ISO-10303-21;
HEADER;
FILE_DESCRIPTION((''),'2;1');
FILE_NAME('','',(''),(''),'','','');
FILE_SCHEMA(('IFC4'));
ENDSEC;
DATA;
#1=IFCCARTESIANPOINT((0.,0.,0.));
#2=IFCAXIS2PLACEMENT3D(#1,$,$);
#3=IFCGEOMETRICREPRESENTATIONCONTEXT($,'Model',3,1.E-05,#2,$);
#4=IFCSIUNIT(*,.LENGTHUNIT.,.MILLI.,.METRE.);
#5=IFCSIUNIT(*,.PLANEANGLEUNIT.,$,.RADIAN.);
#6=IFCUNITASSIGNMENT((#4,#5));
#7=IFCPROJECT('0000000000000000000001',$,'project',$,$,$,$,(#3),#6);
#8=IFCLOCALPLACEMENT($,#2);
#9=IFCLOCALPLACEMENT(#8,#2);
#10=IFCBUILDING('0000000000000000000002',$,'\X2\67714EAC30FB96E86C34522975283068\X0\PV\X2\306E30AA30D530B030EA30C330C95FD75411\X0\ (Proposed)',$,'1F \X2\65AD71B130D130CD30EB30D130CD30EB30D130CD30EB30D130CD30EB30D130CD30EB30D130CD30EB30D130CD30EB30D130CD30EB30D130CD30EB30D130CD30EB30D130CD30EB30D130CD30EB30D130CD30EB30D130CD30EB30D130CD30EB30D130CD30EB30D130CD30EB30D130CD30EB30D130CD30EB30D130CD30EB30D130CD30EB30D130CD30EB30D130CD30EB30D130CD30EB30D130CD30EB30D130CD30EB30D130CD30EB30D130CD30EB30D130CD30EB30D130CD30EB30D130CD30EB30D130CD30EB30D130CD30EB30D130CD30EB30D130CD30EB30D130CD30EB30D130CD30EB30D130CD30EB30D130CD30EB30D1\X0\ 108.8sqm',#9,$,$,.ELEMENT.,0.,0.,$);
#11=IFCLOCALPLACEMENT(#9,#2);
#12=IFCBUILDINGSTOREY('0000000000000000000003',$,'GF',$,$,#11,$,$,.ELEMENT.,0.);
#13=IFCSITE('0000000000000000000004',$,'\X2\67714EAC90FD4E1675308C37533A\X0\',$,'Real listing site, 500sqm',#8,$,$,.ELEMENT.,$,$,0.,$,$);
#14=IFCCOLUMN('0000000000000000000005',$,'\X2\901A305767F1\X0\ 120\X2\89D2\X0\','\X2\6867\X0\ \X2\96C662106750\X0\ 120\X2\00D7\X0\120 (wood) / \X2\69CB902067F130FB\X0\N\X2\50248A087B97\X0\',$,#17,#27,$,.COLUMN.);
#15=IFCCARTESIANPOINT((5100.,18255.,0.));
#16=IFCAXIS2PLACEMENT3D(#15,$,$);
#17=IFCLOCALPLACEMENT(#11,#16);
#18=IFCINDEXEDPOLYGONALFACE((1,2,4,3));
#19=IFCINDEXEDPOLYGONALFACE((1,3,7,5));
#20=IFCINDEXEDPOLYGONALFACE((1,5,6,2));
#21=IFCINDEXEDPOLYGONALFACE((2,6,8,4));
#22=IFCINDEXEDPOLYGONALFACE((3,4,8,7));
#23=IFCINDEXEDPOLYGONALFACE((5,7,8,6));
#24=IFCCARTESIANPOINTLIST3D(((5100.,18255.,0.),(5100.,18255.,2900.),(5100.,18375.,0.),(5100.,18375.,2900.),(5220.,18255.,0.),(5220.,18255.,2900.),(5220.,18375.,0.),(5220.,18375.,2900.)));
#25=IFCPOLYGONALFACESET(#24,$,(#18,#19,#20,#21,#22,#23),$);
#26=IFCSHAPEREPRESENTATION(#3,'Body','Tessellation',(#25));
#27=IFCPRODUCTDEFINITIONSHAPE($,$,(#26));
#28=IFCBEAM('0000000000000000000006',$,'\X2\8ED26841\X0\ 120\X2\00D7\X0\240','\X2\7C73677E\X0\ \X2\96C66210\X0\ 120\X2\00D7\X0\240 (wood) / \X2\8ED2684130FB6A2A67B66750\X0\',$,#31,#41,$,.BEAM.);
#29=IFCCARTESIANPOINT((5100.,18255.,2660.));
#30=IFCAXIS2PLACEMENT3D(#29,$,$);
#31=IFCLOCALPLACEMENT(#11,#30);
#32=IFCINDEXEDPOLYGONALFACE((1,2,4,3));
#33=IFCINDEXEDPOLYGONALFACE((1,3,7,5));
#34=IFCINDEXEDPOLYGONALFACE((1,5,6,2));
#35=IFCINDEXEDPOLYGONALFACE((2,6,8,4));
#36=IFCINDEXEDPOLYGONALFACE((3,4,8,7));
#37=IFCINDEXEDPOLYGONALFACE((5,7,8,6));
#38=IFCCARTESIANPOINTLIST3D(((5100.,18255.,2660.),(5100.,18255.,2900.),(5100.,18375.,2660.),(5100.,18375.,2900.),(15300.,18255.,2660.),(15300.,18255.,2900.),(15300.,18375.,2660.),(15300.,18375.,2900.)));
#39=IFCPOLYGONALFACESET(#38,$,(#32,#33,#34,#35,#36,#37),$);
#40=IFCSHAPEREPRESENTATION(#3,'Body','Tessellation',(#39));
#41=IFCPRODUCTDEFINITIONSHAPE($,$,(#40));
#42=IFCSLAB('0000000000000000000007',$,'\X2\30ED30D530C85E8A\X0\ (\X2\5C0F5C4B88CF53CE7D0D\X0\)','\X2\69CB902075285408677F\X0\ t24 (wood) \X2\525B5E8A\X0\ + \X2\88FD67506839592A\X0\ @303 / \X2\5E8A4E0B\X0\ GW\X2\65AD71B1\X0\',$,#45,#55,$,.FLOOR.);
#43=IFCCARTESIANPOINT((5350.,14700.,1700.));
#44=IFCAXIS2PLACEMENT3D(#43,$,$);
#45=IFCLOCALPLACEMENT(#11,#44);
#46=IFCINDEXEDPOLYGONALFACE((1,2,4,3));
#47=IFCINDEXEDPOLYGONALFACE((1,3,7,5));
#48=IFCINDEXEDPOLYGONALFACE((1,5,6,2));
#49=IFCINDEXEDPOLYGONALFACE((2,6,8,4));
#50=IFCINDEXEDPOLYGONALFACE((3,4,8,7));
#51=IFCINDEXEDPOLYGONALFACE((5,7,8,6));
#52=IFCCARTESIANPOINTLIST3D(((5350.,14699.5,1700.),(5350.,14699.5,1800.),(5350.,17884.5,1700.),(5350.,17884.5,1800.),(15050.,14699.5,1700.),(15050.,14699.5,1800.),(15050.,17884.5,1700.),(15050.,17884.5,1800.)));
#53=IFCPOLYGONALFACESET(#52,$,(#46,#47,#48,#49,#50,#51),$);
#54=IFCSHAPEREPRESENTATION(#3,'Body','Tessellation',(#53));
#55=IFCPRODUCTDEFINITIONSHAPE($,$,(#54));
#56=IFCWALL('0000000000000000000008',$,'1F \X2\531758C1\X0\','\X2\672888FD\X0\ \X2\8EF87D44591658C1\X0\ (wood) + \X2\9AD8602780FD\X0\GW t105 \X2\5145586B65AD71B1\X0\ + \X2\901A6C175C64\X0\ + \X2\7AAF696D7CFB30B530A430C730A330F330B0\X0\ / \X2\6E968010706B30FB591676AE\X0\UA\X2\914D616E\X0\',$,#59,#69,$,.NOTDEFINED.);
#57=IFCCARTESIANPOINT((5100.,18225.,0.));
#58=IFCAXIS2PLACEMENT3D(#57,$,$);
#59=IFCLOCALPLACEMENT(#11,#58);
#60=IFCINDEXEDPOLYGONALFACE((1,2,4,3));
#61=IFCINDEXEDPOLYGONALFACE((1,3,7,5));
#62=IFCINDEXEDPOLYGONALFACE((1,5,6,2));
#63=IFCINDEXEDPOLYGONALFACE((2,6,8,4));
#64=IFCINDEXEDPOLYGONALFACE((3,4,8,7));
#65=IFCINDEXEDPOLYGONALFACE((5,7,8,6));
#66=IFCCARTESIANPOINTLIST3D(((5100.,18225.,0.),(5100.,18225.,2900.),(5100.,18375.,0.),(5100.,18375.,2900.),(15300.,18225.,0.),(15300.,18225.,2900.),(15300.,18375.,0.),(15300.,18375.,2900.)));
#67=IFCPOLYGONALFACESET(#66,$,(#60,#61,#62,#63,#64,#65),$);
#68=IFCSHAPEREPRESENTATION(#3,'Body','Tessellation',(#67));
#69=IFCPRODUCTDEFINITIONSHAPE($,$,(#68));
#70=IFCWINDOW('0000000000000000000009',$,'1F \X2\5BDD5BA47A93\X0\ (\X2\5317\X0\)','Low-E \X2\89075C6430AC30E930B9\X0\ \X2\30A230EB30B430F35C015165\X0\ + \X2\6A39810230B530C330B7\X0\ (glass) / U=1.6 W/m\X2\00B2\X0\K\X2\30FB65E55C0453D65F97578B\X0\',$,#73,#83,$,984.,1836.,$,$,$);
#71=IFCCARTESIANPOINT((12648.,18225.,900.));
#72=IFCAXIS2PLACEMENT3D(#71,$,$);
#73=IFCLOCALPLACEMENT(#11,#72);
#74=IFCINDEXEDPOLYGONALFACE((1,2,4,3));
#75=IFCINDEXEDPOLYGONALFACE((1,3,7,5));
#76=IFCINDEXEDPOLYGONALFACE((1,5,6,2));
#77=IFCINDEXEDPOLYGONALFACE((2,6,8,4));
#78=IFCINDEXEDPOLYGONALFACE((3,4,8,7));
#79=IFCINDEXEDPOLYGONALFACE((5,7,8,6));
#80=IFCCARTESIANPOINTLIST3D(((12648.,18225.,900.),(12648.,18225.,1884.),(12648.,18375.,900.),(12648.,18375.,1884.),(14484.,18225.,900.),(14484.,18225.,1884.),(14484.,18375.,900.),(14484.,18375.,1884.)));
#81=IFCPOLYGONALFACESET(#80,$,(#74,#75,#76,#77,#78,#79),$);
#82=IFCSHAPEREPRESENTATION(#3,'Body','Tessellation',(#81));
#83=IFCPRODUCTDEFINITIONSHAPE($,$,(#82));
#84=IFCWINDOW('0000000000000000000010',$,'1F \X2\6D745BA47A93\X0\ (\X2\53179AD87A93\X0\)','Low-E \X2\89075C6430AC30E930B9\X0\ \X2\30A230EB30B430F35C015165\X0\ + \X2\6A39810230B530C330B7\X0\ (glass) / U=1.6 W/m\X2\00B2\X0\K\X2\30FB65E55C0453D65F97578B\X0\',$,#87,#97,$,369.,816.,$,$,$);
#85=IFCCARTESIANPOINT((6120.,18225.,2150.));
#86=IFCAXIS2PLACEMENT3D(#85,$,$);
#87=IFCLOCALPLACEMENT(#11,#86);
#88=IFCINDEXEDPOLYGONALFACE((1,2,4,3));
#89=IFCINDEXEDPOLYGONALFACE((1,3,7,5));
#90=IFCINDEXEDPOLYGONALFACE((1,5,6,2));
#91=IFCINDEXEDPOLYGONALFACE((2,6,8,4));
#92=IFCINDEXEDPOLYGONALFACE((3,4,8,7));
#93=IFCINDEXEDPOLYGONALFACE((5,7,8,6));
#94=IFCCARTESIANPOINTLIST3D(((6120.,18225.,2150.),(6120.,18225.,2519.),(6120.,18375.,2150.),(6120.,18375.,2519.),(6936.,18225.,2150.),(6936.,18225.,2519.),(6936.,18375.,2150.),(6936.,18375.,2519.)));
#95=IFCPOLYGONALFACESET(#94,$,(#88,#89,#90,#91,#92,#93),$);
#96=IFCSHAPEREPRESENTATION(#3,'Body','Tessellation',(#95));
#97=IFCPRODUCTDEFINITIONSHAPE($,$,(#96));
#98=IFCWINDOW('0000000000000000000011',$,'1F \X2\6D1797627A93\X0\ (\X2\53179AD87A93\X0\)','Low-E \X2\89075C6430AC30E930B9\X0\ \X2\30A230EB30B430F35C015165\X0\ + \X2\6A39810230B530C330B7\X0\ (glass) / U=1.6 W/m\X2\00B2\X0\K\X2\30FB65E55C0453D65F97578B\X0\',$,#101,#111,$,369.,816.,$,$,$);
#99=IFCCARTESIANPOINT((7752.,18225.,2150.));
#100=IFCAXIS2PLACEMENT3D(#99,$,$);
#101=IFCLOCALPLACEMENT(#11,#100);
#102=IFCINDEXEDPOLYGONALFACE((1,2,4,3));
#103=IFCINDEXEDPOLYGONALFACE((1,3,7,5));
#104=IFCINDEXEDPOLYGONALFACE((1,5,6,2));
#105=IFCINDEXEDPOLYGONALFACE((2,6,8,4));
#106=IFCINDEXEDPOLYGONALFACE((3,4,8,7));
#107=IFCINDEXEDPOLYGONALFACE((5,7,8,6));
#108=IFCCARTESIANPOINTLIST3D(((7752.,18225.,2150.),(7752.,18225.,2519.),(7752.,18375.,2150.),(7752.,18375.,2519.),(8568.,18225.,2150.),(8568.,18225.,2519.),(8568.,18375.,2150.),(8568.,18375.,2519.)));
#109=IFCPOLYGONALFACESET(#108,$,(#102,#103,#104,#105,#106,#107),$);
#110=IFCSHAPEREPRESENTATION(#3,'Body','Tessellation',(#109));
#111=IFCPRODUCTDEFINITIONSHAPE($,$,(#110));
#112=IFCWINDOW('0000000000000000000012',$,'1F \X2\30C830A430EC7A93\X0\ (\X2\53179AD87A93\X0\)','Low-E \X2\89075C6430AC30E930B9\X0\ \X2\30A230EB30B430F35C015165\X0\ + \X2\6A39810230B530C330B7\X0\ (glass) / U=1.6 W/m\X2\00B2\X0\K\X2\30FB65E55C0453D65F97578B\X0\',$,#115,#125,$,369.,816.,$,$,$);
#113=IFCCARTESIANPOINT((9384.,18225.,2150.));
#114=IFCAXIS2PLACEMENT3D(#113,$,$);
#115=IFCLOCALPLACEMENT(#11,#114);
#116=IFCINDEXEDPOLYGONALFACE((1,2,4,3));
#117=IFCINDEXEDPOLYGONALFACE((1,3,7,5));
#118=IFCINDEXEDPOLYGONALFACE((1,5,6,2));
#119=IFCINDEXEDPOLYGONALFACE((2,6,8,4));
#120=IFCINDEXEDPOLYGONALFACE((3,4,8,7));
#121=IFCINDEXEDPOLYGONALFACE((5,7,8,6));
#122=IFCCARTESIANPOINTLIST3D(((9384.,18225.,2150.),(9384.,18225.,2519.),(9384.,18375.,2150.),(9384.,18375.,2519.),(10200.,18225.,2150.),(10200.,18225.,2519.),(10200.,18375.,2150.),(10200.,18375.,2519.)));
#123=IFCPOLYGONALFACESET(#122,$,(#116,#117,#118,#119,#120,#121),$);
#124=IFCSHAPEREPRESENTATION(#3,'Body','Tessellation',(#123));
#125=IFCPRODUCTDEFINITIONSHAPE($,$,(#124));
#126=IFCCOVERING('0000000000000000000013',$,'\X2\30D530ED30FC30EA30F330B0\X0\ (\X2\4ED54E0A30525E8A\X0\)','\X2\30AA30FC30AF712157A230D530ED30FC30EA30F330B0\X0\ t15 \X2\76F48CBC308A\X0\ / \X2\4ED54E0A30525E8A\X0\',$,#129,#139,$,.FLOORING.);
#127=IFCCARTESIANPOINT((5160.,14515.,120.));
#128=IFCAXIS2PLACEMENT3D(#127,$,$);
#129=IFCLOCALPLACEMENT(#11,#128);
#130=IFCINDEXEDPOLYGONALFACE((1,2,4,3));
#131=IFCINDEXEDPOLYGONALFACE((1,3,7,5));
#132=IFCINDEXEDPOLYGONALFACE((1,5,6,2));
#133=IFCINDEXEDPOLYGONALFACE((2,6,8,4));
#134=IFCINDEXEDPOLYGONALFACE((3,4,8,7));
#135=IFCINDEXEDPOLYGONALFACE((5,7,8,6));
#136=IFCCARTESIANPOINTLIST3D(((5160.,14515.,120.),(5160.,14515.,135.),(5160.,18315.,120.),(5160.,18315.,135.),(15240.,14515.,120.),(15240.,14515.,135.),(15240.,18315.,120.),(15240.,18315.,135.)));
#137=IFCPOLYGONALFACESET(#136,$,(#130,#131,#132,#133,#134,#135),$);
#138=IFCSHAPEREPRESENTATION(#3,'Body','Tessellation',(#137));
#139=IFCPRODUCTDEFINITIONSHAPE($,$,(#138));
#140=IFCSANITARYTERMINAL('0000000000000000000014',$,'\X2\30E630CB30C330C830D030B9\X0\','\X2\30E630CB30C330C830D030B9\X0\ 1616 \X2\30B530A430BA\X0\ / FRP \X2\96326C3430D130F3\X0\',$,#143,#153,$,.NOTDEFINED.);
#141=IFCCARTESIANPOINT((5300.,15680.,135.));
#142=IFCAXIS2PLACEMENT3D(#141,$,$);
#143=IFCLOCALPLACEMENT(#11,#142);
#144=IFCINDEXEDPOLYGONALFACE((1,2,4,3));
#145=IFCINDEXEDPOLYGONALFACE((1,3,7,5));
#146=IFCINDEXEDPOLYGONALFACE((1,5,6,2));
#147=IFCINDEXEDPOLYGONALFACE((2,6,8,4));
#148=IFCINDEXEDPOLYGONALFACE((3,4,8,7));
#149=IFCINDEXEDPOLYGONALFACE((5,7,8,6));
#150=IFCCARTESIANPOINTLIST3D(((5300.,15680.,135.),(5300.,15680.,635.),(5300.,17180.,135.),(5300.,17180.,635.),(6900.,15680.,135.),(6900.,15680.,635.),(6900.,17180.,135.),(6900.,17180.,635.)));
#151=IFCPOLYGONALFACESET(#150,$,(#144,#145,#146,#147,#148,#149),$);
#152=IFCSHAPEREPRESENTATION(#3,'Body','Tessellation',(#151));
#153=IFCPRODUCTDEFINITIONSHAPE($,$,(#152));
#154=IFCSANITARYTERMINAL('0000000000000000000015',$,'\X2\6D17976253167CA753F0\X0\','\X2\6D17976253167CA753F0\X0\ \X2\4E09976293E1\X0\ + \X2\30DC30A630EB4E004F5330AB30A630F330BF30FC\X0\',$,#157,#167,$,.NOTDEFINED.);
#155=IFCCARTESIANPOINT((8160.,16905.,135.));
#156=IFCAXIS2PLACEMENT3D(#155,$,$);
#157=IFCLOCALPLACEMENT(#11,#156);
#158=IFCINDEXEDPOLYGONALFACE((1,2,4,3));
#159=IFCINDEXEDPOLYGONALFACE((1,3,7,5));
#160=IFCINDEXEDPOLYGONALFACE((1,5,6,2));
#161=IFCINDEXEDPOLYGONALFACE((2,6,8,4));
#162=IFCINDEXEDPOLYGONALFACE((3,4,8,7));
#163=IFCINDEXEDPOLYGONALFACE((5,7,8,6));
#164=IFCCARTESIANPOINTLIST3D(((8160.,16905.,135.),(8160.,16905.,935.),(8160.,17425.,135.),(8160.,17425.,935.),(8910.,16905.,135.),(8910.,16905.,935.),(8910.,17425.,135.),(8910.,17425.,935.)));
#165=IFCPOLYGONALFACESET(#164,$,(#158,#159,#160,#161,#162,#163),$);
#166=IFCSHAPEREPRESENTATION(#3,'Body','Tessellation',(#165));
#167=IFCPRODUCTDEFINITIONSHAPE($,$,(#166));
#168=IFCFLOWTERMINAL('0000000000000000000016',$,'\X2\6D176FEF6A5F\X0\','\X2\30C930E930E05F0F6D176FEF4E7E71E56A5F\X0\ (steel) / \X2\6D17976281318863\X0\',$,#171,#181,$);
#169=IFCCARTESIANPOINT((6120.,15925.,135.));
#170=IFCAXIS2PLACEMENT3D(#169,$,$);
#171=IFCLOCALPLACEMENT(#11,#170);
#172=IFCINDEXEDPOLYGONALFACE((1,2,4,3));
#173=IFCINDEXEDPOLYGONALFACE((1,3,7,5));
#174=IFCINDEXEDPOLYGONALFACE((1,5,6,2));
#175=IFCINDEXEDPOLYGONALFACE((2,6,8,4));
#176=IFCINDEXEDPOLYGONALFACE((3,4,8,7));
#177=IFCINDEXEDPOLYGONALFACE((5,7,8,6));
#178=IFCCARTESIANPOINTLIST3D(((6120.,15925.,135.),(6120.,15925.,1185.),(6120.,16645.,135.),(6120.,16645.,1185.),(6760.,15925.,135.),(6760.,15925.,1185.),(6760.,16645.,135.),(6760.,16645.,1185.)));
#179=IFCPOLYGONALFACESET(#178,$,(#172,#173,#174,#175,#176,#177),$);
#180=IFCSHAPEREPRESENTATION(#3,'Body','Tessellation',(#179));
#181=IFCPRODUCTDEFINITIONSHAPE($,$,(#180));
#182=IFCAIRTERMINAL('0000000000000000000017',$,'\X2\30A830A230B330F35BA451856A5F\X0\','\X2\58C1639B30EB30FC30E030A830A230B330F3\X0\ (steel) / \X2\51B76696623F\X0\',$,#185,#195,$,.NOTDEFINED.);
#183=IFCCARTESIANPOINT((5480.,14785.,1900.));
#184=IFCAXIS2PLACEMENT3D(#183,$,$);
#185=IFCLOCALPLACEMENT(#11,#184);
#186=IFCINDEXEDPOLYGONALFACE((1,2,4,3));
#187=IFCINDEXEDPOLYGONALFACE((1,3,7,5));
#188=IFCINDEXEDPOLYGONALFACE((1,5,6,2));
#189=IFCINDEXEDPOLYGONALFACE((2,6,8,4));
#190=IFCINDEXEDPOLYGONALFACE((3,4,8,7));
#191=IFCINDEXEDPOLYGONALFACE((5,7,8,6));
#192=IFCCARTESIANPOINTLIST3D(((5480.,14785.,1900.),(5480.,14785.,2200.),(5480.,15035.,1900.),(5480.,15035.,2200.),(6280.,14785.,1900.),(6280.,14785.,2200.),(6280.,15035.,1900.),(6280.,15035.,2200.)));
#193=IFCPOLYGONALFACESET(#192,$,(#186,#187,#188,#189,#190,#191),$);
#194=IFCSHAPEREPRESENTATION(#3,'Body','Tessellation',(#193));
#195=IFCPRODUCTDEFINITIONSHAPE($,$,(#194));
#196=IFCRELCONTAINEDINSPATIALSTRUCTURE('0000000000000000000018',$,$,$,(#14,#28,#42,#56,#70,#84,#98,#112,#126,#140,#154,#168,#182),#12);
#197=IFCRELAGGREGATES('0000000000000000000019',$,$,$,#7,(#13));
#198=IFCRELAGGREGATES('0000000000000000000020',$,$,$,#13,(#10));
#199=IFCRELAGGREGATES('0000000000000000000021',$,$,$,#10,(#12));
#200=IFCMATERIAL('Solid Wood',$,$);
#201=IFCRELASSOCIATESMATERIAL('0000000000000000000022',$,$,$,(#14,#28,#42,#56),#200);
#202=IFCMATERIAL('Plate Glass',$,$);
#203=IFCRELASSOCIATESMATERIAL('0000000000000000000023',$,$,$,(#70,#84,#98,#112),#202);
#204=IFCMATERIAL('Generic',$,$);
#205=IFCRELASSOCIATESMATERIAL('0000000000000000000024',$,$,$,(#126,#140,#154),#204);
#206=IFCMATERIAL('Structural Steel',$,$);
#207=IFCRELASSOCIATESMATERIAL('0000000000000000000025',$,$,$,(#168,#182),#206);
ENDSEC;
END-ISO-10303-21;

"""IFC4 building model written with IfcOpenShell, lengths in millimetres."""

from ifc_helpers import new_model, si_unit, frame, frame_2d, origin, place, context, project, spatial, rectangle, extrude, material, element, fill, save


model = new_model("IFC4")

# Units and contexts
model_context = context("Model", 3, precision=1e-05, world=origin())
ifc_project = project(units=[si_unit("LENGTHUNIT", "METRE", prefix="MILLI"), si_unit("PLANEANGLEUNIT", "RADIAN")], contexts=[model_context])

# Site, building, storey
site_placement = place(None, origin())
site = spatial("IfcSite", under=ifc_project, at=site_placement, Name="東京都世田谷区", ObjectType="Real listing site, 500sqm", CompositionType="ELEMENT", RefElevation=0.0)
building_placement = place(site_placement, origin())
building = spatial("IfcBuilding", under=site, at=building_placement, Name="東京・雨水利用とPVのオフグリッド志向 (Proposed)", ObjectType="1F 断熱パネルパネルパネルパネルパネルパネルパネルパネルパネルパネルパネルパネルパネルパネルパネルパネルパネルパネルパネルパネルパネルパネルパネルパネルパネルパネルパネルパネルパネルパネルパネルパネルパネルパネルパネルパネルパネルパネルパネルパ 108.8sqm", CompositionType="ELEMENT", ElevationOfRefHeight=0.0, ElevationOfTerrain=0.0)
storey_placement = place(building_placement, origin())
storey = spatial("IfcBuildingStorey", under=building, at=storey_placement, Name="GF", CompositionType="ELEMENT", Elevation=0.0)

# Column
ifc_material_1 = material(Name="Solid Wood")
column_1_placement = place(storey_placement, frame((5100.0, 18255.0, 0.0)))
element("IfcColumn", 1, at=column_1_placement, inside=storey, material=ifc_material_1, Name="通し柱 120角", Description="桧 集成材 120×120 (wood) / 構造柱・N値計算", PredefinedType="COLUMN", context=model_context, shape_type="SweptSolid", body=[
    extrude(rectangle(XDim=120.0, YDim=120.0, at=frame_2d((60.0, 60.0))), frame((5100.0, 18255.0, 0.0)), (0.0, 0.0, 1.0), 2900.0),
])

# Beam
beam_1_placement = place(storey_placement, frame((5100.0, 18255.0, 2660.0)))
element("IfcBeam", 2, at=beam_1_placement, inside=storey, material=ifc_material_1, Name="軒桁 120×240", Description="米松 集成 120×240 (wood) / 軒桁・横架材", PredefinedType="BEAM", context=model_context, shape_type="SweptSolid", body=[
    extrude(rectangle(XDim=10200.0, YDim=120.0, at=frame_2d((5100.0, 60.0))), frame((5100.0, 18255.0, 2660.0)), (0.0, 0.0, 1.0), 240.0),
])

# Slab
slab_placement = place(storey_placement, frame((5350.0, 14700.0, 1700.0)))
element("IfcSlab", 3, at=slab_placement, inside=storey, material=ifc_material_1, Name="ロフト床 (小屋裏収納)", Description="構造用合板 t24 (wood) 剛床 + 製材根太 @303 / 床下 GW断熱", PredefinedType="FLOOR", context=model_context, shape_type="SweptSolid", body=[
    extrude(rectangle(XDim=9700.0, YDim=3185.0, at=frame_2d((4850.0, 1592.0))), frame((5350.0, 14700.0, 1700.0)), (0.0, 0.0, 1.0), 100.0),
])

# Wall, openings, windows
wall_1_placement = place(storey_placement, frame((5100.0, 18225.0, 0.0)))
wall_1 = element("IfcWall", 4, at=wall_1_placement, inside=storey, material=ifc_material_1, Name="1F 北壁", Description="木製 軸組外壁 (wood) + 高性能GW t105 充填断熱 + 通気層 + 窯業系サイディング / 準耐火・外皮UA配慮", PredefinedType="NOTDEFINED", context=model_context, shape_type="SweptSolid", body=[
    extrude(rectangle(XDim=10200.0, YDim=150.0, at=frame_2d((5100.0, 75.0))), frame((5100.0, 18225.0, 0.0)), (0.0, 0.0, 1.0), 2900.0),
])
opening_1_placement = place(storey_placement, frame((12648.0, 18225.0, 900.0)))
opening_1 = element("IfcOpeningElement", 5, at=opening_1_placement, cuts=wall_1, PredefinedType="NOTDEFINED", context=model_context, shape_type="SweptSolid", body=[
    extrude(rectangle(XDim=1836.0, YDim=150.0, at=frame_2d((918.0, 75.0))), frame((12648.0, 18225.0, 900.0)), (0.0, 0.0, 1.0), 984.0),
])
opening_2_placement = place(storey_placement, frame((6120.0, 18225.0, 2150.0)))
opening_2 = element("IfcOpeningElement", 6, at=opening_2_placement, cuts=wall_1, PredefinedType="NOTDEFINED", context=model_context, shape_type="SweptSolid", body=[
    extrude(rectangle(XDim=816.0, YDim=150.0, at=frame_2d((408.0, 75.0))), frame((6120.0, 18225.0, 2150.0)), (0.0, 0.0, 1.0), 369.0),
])
opening_3_placement = place(storey_placement, frame((7752.0, 18225.0, 2150.0)))
opening_3 = element("IfcOpeningElement", 7, at=opening_3_placement, cuts=wall_1, PredefinedType="NOTDEFINED", context=model_context, shape_type="SweptSolid", body=[
    extrude(rectangle(XDim=816.0, YDim=150.0, at=frame_2d((408.0, 75.0))), frame((7752.0, 18225.0, 2150.0)), (0.0, 0.0, 1.0), 369.0),
])
opening_4_placement = place(storey_placement, frame((9384.0, 18225.0, 2150.0)))
opening_4 = element("IfcOpeningElement", 8, at=opening_4_placement, cuts=wall_1, PredefinedType="NOTDEFINED", context=model_context, shape_type="SweptSolid", body=[
    extrude(rectangle(XDim=816.0, YDim=150.0, at=frame_2d((408.0, 75.0))), frame((9384.0, 18225.0, 2150.0)), (0.0, 0.0, 1.0), 369.0),
])
ifc_material_2 = material(Name="Plate Glass")
window_1_placement = place(storey_placement, frame((12648.0, 18225.0, 900.0)))
window_1 = element("IfcWindow", 9, at=window_1_placement, inside=storey, material=ifc_material_2, Name="1F 寝室窓 (北)", Description="Low-E 複層ガラス アルゴン封入 + 樹脂サッシ (glass) / U=1.6 W/m²K・日射取得型", OverallHeight=984.0, OverallWidth=1836.0, context=model_context, shape_type="SweptSolid", body=[
    extrude(rectangle(XDim=1836.0, YDim=150.0, at=frame_2d((918.0, 75.0))), frame((12648.0, 18225.0, 900.0)), (0.0, 0.0, 1.0), 984.0),
])
fill(opening_1, window_1)
window_2_placement = place(storey_placement, frame((6120.0, 18225.0, 2150.0)))
window_2 = element("IfcWindow", 10, at=window_2_placement, inside=storey, material=ifc_material_2, Name="1F 浴室窓 (北高窓)", Description="Low-E 複層ガラス アルゴン封入 + 樹脂サッシ (glass) / U=1.6 W/m²K・日射取得型", OverallHeight=369.0, OverallWidth=816.0, context=model_context, shape_type="SweptSolid", body=[
    extrude(rectangle(XDim=816.0, YDim=150.0, at=frame_2d((408.0, 75.0))), frame((6120.0, 18225.0, 2150.0)), (0.0, 0.0, 1.0), 369.0),
])
fill(opening_2, window_2)
window_3_placement = place(storey_placement, frame((7752.0, 18225.0, 2150.0)))
window_3 = element("IfcWindow", 11, at=window_3_placement, inside=storey, material=ifc_material_2, Name="1F 洗面窓 (北高窓)", Description="Low-E 複層ガラス アルゴン封入 + 樹脂サッシ (glass) / U=1.6 W/m²K・日射取得型", OverallHeight=369.0, OverallWidth=816.0, context=model_context, shape_type="SweptSolid", body=[
    extrude(rectangle(XDim=816.0, YDim=150.0, at=frame_2d((408.0, 75.0))), frame((7752.0, 18225.0, 2150.0)), (0.0, 0.0, 1.0), 369.0),
])
fill(opening_3, window_3)
window_4_placement = place(storey_placement, frame((9384.0, 18225.0, 2150.0)))
window_4 = element("IfcWindow", 12, at=window_4_placement, inside=storey, material=ifc_material_2, Name="1F トイレ窓 (北高窓)", Description="Low-E 複層ガラス アルゴン封入 + 樹脂サッシ (glass) / U=1.6 W/m²K・日射取得型", OverallHeight=369.0, OverallWidth=816.0, context=model_context, shape_type="SweptSolid", body=[
    extrude(rectangle(XDim=816.0, YDim=150.0, at=frame_2d((408.0, 75.0))), frame((9384.0, 18225.0, 2150.0)), (0.0, 0.0, 1.0), 369.0),
])
fill(opening_4, window_4)

# Covering
ifc_material_3 = material(Name="Generic")
covering_placement = place(storey_placement, frame((5160.0, 14515.0, 120.0)))
element("IfcCovering", 13, at=covering_placement, inside=storey, material=ifc_material_3, Name="フローリング (仕上げ床)", Description="オーク無垢フローリング t15 直貼り / 仕上げ床", PredefinedType="FLOORING", context=model_context, shape_type="SweptSolid", body=[
    extrude(rectangle(XDim=10080.0, YDim=3800.0, at=frame_2d((5040.0, 1900.0))), frame((5160.0, 14515.0, 120.0)), (0.0, 0.0, 1.0), 15.0),
])

# Sanitary terminals
sanitary_terminal_1_placement = place(storey_placement, frame((5300.0, 15680.0, 135.0)))
element("IfcSanitaryTerminal", 14, at=sanitary_terminal_1_placement, inside=storey, material=ifc_material_3, Name="ユニットバス", Description="ユニットバス 1616 サイズ / FRP 防水パン", PredefinedType="NOTDEFINED", context=model_context, shape_type="SweptSolid", body=[
    extrude(rectangle(XDim=1600.0, YDim=1500.0, at=frame_2d((800.0, 750.0))), frame((5300.0, 15680.0, 135.0)), (0.0, 0.0, 1.0), 500.0),
])
sanitary_terminal_2_placement = place(storey_placement, frame((8160.0, 16905.0, 135.0)))
element("IfcSanitaryTerminal", 15, at=sanitary_terminal_2_placement, inside=storey, material=ifc_material_3, Name="洗面化粧台", Description="洗面化粧台 三面鏡 + ボウル一体カウンター", PredefinedType="NOTDEFINED", context=model_context, shape_type="SweptSolid", body=[
    extrude(rectangle(XDim=750.0, YDim=520.0, at=frame_2d((375.0, 260.0))), frame((8160.0, 16905.0, 135.0)), (0.0, 0.0, 1.0), 800.0),
])

# Flow terminal
ifc_material_4 = material(Name="Structural Steel")
flow_terminal_placement = place(storey_placement, frame((6120.0, 15925.0, 135.0)))
element("IfcFlowTerminal", 16, at=flow_terminal_placement, inside=storey, material=ifc_material_4, Name="洗濯機", Description="ドラム式洗濯乾燥機 (steel) / 洗面脱衣", context=model_context, shape_type="SweptSolid", body=[
    extrude(rectangle(XDim=640.0, YDim=720.0, at=frame_2d((320.0, 360.0))), frame((6120.0, 15925.0, 135.0)), (0.0, 0.0, 1.0), 1050.0),
])

# Air terminal
air_terminal_placement = place(storey_placement, frame((5480.0, 14785.0, 1900.0)))
element("IfcAirTerminal", 17, at=air_terminal_placement, inside=storey, material=ifc_material_4, Name="エアコン室内機", Description="壁掛ルームエアコン (steel) / 冷暖房", PredefinedType="NOTDEFINED", context=model_context, shape_type="SweptSolid", body=[
    extrude(rectangle(XDim=800.0, YDim=250.0, at=frame_2d((400.0, 125.0))), frame((5480.0, 14785.0, 1900.0)), (0.0, 0.0, 1.0), 300.0),
])

save(model, "model.ifc")
